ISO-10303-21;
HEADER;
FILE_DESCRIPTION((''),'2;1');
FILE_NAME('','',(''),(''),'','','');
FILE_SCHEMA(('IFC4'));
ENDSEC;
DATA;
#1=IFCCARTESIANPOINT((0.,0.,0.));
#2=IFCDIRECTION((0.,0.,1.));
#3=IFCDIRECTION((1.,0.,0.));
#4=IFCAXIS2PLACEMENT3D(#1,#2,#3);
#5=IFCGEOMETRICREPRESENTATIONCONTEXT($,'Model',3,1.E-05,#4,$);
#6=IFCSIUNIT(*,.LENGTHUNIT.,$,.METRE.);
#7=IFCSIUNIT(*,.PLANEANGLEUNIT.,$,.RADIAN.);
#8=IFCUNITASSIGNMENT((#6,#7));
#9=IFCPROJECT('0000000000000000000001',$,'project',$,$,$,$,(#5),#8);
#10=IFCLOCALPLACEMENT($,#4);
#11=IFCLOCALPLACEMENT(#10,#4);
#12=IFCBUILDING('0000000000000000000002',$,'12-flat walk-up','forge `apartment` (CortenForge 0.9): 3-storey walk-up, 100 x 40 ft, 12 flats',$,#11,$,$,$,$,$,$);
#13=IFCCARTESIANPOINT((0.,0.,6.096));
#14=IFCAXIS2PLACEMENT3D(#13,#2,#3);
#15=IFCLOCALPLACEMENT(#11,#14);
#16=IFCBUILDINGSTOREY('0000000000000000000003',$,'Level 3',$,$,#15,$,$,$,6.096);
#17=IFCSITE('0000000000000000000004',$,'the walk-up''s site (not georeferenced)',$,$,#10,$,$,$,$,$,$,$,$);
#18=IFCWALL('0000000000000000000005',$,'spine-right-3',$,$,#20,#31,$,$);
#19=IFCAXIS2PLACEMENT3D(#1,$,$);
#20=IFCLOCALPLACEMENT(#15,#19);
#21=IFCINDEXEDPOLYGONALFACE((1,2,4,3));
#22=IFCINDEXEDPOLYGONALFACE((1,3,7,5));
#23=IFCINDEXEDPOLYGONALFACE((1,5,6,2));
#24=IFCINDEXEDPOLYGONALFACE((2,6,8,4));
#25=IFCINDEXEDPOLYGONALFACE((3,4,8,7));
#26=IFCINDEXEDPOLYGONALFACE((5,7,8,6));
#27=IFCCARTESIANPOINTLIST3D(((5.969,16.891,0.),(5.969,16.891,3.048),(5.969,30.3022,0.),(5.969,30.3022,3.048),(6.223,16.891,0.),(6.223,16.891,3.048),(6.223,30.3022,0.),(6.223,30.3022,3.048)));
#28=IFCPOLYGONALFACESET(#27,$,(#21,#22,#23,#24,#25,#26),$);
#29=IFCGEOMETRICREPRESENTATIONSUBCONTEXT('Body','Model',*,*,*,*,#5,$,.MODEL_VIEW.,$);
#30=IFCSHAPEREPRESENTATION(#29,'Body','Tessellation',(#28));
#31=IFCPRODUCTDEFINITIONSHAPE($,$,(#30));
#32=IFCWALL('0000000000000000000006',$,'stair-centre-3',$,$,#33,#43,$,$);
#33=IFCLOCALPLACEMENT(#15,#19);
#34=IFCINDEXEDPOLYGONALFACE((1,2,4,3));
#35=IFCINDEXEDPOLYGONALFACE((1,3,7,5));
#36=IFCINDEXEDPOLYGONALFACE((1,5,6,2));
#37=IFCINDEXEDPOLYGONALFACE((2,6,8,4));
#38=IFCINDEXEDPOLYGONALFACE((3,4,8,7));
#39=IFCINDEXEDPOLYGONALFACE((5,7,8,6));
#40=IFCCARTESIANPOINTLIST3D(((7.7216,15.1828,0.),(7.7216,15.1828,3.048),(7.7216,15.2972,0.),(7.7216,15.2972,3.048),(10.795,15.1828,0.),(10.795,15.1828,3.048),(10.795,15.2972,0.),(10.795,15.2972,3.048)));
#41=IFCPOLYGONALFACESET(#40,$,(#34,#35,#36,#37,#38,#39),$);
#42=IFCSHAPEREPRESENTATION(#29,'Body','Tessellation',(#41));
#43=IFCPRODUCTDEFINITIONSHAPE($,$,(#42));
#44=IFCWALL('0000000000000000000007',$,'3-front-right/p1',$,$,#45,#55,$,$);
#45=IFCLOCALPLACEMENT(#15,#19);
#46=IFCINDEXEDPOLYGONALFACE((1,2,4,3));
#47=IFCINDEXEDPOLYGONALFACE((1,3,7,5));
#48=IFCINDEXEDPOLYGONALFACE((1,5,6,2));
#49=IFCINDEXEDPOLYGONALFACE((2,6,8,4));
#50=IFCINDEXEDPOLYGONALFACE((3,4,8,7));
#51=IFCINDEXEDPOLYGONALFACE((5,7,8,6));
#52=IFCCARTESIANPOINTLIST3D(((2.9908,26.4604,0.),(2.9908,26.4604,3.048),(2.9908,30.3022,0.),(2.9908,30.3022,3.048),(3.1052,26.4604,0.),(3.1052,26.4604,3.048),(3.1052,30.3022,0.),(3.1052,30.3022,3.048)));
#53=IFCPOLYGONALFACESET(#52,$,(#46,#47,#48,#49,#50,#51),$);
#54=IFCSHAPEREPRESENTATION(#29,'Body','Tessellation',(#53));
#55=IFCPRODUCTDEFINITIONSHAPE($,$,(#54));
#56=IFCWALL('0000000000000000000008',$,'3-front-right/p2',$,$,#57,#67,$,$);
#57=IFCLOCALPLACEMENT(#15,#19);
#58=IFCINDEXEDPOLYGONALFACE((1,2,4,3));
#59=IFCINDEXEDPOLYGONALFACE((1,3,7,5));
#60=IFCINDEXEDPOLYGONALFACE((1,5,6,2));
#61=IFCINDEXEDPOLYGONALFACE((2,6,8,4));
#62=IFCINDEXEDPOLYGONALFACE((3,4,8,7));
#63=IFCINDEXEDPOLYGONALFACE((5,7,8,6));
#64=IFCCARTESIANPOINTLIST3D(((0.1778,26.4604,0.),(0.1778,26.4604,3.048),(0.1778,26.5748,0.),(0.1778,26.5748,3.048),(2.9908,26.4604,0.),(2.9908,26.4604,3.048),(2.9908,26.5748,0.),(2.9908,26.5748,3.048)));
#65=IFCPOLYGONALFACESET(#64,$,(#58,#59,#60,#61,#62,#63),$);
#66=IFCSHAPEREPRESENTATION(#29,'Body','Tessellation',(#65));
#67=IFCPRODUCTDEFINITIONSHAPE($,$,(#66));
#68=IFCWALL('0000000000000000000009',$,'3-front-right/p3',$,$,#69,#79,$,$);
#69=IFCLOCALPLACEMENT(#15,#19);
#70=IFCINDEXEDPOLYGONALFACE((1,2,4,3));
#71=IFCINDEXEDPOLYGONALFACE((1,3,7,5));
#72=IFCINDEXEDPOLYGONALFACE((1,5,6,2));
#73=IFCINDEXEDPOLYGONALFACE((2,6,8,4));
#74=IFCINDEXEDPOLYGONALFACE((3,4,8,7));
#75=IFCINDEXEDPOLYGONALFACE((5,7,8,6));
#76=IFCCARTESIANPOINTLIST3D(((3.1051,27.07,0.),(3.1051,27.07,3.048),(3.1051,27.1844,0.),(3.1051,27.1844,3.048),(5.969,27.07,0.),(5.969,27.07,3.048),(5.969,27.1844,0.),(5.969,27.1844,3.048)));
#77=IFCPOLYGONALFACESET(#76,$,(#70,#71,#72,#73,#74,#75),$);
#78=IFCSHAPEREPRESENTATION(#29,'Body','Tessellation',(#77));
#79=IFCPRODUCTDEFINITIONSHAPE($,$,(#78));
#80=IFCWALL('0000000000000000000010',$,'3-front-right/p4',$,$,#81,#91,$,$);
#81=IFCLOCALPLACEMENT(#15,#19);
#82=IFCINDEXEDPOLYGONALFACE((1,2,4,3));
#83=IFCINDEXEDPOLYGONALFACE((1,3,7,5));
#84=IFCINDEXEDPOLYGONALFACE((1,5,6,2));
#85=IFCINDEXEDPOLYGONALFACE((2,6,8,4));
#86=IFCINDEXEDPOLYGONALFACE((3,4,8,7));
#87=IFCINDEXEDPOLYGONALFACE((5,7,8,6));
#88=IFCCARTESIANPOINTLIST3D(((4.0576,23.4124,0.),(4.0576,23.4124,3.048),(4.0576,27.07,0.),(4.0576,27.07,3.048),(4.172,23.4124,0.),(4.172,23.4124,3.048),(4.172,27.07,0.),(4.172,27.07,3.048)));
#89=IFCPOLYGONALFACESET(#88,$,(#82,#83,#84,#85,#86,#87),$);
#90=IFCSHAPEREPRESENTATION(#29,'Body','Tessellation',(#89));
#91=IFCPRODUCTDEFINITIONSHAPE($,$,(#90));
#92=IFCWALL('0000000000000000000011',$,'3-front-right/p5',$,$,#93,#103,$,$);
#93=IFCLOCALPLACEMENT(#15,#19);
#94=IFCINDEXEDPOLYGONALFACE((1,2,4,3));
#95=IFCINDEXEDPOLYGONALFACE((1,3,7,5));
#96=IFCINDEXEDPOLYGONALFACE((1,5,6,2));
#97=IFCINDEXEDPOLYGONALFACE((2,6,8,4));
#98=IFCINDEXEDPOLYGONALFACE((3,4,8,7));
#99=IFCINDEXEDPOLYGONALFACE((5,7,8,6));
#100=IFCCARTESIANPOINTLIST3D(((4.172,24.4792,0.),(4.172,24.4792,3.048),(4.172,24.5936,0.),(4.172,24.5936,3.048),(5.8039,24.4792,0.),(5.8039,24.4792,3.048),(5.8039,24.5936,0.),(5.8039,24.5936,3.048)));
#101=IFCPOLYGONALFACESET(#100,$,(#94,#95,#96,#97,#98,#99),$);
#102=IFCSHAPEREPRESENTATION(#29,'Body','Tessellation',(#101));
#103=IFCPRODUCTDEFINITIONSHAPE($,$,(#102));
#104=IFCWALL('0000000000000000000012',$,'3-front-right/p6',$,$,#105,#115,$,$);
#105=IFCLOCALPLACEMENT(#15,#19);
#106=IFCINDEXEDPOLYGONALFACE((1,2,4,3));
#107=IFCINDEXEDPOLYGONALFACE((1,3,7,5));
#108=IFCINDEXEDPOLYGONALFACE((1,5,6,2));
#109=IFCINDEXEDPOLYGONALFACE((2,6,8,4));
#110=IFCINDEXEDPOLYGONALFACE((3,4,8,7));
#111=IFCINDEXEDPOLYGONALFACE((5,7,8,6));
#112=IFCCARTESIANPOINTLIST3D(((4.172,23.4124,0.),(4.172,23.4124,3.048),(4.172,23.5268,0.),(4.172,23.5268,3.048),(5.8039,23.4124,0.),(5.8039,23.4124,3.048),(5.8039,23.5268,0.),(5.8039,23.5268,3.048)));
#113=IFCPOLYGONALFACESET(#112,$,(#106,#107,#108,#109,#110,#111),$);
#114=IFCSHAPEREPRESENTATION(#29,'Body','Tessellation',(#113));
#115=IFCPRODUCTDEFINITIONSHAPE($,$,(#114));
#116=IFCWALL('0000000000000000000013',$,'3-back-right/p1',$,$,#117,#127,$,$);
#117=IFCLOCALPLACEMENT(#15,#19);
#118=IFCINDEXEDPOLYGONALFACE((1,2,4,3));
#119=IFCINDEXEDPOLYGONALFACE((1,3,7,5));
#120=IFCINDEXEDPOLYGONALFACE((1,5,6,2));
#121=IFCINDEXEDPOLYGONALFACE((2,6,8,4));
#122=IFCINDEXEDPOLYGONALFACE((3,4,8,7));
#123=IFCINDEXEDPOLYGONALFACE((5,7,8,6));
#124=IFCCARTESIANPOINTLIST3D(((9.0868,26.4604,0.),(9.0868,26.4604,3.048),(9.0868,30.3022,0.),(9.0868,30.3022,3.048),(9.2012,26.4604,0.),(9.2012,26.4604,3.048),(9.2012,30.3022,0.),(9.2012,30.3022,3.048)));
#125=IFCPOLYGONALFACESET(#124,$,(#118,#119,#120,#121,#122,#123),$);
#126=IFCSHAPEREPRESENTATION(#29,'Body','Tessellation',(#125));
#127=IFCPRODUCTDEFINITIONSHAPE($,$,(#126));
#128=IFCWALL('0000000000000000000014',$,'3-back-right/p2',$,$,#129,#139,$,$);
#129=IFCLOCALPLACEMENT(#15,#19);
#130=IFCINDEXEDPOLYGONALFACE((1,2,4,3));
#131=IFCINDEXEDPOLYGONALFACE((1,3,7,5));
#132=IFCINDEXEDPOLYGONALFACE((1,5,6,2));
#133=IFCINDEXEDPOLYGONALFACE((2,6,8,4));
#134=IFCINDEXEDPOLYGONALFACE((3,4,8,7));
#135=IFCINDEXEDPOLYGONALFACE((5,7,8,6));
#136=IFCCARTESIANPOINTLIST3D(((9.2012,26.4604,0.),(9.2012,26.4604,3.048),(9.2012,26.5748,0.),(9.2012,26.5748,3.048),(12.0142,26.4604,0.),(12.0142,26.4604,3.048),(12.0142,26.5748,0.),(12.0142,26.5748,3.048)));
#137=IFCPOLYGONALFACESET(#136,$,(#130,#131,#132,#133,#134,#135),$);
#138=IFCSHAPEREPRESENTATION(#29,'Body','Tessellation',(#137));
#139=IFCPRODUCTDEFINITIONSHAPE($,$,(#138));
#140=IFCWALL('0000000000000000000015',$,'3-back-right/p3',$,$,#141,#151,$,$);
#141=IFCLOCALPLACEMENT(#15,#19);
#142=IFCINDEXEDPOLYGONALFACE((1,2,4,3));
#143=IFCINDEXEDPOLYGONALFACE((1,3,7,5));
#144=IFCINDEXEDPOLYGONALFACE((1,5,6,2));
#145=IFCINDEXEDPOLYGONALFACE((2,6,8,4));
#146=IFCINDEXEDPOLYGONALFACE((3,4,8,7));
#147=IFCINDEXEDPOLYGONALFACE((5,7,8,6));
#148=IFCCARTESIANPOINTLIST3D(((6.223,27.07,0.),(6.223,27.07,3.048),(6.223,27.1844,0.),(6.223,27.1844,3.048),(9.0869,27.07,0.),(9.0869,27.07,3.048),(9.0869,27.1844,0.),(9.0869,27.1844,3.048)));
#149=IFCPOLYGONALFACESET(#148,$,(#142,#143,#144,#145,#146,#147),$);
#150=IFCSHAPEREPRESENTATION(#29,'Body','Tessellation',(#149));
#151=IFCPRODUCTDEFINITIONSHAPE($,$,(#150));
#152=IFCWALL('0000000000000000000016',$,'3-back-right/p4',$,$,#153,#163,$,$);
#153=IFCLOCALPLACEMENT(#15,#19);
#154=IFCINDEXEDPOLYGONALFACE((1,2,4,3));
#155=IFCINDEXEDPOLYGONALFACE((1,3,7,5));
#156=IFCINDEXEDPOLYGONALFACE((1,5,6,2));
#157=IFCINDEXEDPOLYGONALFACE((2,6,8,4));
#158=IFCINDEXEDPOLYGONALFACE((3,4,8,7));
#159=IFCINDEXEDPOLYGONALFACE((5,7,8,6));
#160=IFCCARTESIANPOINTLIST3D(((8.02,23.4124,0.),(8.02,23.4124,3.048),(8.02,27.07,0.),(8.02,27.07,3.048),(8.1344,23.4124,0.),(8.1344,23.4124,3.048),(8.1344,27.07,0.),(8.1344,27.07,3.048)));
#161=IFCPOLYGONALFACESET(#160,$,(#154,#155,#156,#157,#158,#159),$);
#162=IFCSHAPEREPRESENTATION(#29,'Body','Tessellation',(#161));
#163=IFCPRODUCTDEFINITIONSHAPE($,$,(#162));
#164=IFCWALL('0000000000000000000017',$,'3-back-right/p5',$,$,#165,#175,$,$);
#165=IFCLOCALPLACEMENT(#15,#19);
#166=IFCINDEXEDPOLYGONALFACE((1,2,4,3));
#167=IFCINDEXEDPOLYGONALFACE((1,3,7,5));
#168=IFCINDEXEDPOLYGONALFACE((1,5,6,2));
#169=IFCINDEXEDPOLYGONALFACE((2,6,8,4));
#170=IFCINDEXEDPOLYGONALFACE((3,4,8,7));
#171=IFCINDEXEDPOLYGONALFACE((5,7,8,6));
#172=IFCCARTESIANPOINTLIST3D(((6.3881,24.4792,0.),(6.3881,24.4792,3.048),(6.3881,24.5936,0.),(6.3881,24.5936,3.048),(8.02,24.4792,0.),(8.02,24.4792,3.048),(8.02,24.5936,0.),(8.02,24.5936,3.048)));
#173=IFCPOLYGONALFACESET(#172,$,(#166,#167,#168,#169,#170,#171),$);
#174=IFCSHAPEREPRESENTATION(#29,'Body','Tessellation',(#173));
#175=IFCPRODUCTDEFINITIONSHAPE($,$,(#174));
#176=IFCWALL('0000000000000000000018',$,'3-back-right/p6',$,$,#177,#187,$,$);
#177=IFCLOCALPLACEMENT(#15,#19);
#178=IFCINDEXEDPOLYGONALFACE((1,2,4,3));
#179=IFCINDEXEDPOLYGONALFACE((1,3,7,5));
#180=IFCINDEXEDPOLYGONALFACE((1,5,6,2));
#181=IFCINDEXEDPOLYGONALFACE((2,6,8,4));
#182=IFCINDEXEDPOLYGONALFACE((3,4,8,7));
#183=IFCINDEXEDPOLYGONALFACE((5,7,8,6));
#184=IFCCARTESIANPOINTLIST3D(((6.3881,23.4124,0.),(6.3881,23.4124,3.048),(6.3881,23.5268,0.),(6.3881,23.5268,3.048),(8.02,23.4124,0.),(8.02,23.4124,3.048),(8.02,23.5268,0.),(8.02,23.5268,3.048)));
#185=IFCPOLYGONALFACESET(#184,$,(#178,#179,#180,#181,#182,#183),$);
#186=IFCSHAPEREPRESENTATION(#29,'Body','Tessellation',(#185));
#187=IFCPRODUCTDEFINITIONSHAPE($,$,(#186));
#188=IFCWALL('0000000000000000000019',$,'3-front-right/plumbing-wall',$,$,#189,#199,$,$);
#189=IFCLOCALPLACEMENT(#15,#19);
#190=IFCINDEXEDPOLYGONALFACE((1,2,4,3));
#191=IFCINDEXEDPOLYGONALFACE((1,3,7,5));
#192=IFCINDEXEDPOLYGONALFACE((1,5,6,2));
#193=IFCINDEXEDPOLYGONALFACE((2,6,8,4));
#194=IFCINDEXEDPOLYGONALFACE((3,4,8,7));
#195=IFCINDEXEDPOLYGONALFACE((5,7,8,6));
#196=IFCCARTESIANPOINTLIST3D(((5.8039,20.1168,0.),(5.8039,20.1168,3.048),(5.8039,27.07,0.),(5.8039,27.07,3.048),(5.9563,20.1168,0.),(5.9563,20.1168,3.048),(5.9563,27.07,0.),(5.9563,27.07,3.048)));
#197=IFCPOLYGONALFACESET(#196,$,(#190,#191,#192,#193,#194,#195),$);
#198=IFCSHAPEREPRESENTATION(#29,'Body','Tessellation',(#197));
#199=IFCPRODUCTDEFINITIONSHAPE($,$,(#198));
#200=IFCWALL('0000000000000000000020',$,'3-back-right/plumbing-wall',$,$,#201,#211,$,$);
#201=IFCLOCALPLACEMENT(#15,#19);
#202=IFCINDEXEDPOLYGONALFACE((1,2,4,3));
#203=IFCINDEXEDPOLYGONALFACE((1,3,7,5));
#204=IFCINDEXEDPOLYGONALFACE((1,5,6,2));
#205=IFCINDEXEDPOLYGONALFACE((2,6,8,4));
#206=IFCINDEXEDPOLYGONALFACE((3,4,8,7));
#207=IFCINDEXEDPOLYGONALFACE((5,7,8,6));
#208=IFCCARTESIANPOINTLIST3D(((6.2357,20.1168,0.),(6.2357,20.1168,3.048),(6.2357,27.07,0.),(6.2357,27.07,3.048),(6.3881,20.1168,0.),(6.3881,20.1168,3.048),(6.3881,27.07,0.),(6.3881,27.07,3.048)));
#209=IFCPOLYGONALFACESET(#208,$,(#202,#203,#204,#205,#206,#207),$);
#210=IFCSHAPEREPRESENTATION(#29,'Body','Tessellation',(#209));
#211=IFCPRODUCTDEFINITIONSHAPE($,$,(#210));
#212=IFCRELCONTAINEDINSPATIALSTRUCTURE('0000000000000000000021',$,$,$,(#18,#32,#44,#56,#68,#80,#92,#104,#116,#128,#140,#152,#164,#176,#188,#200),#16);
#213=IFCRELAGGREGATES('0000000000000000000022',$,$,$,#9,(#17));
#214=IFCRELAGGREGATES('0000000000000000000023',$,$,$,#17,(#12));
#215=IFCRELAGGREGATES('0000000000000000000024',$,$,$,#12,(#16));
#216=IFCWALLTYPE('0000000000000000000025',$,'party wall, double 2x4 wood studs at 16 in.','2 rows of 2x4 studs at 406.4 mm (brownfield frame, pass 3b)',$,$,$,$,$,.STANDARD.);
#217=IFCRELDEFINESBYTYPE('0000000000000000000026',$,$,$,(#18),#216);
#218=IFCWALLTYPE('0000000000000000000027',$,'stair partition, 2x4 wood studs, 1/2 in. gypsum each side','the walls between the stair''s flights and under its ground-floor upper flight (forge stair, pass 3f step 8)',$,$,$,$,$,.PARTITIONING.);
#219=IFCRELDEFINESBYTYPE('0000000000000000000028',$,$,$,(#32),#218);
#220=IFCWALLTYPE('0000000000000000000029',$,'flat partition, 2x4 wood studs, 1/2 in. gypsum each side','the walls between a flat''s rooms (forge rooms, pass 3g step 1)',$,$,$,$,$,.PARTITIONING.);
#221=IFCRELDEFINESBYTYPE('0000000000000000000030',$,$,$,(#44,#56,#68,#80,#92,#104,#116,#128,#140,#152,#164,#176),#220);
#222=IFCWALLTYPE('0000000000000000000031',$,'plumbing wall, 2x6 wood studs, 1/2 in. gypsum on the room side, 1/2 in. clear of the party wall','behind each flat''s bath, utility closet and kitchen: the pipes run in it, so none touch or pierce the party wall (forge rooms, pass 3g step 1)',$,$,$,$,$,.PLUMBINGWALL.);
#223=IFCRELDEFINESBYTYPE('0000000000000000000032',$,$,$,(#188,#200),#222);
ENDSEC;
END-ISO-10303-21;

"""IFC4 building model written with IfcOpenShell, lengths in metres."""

from ifc_helpers import new_model, si_unit, frame, frame_2d, origin, origin_with_axes, place, context, subcontext, project, spatial, rectangle, extrude, type_object, element, save


model = new_model("IFC4")

# Units and contexts
model_context = context("Model", 3, precision=1e-05, world=origin_with_axes())
body_context = subcontext(model_context, "Body", "Model", "MODEL_VIEW")
ifc_project = project(units=[si_unit("LENGTHUNIT", "METRE"), si_unit("PLANEANGLEUNIT", "RADIAN")], contexts=[model_context])

# Site, building, storey
site_placement = place(None, origin_with_axes())
site = spatial("IfcSite", under=ifc_project, at=site_placement, Name="the walk-up's site (not georeferenced)")
building_placement = place(site_placement, origin_with_axes())
building = spatial("IfcBuilding", under=site, at=building_placement, Name="12-flat walk-up", Description="forge `apartment` (CortenForge 0.9): 3-storey walk-up, 100 x 40 ft, 12 flats")
storey_placement = place(building_placement, frame((0.0, 0.0, 6.096), z_axis=(0.0, 0.0, 1.0), x_axis=(1.0, 0.0, 0.0)))
storey = spatial("IfcBuildingStorey", under=building, at=storey_placement, Name="Level 3", Elevation=6.096)

# Walls
wall_type_1 = type_object("IfcWallType", Name="party wall, double 2x4 wood studs at 16 in.", Description="2 rows of 2x4 studs at 406.4 mm (brownfield frame, pass 3b)", PredefinedType="STANDARD")
wall_1_placement = place(storey_placement, frame((5.969, 16.891, 0.0), z_axis=(0.0, 0.0, 1.0), x_axis=(1.0, 0.0, 0.0)))
element("IfcWall", 1, at=wall_1_placement, inside=storey, type_object=wall_type_1, Name="spine-right-3", context=body_context, shape_type="SweptSolid", body=[
    extrude(rectangle(XDim=0.254, YDim=13.4112, at=frame_2d((0.127, 6.7056))), origin(), (0.0, 0.0, 1.0), 3.048),
])
wall_type_2 = type_object("IfcWallType", Name="stair partition, 2x4 wood studs, 1/2 in. gypsum each side", Description="the walls between the stair's flights and under its ground-floor upper flight (forge stair, pass 3f step 8)", PredefinedType="PARTITIONING")
wall_2_placement = place(storey_placement, frame((7.7216, 15.1829, 0.0), z_axis=(0.0, 0.0, 1.0), x_axis=(1.0, 0.0, 0.0)))
element("IfcWall", 2, at=wall_2_placement, inside=storey, type_object=wall_type_2, Name="stair-centre-3", context=body_context, shape_type="SweptSolid", body=[
    extrude(rectangle(XDim=3.0734, YDim=0.1143, at=frame_2d((1.5367, 0.0572))), origin(), (0.0, 0.0, 1.0), 3.048),
])
wall_type_3 = type_object("IfcWallType", Name="flat partition, 2x4 wood studs, 1/2 in. gypsum each side", Description="the walls between a flat's rooms (forge rooms, pass 3g step 1)", PredefinedType="PARTITIONING")
wall_3_placement = place(storey_placement, frame((2.9909, 26.4605, 0.0), z_axis=(0.0, 0.0, 1.0), x_axis=(1.0, 0.0, 0.0)))
element("IfcWall", 3, at=wall_3_placement, inside=storey, type_object=wall_type_3, Name="3-front-right/p1", context=body_context, shape_type="SweptSolid", body=[
    extrude(rectangle(XDim=0.1143, YDim=3.8417, at=frame_2d((0.0572, 1.9209))), origin(), (0.0, 0.0, 1.0), 3.048),
])
wall_4_placement = place(storey_placement, frame((0.1778, 26.4605, 0.0), z_axis=(0.0, 0.0, 1.0), x_axis=(1.0, 0.0, 0.0)))
element("IfcWall", 4, at=wall_4_placement, inside=storey, type_object=wall_type_3, Name="3-front-right/p2", context=body_context, shape_type="SweptSolid", body=[
    extrude(rectangle(XDim=2.8131, YDim=0.1143, at=frame_2d((1.4065, 0.0572))), origin(), (0.0, 0.0, 1.0), 3.048),
])
wall_5_placement = place(storey_placement, frame((3.1051, 27.07, 0.0), z_axis=(0.0, 0.0, 1.0), x_axis=(1.0, 0.0, 0.0)))
element("IfcWall", 5, at=wall_5_placement, inside=storey, type_object=wall_type_3, Name="3-front-right/p3", context=body_context, shape_type="SweptSolid", body=[
    extrude(rectangle(XDim=2.8639, YDim=0.1143, at=frame_2d((1.4319, 0.0572))), origin(), (0.0, 0.0, 1.0), 3.048),
])
wall_6_placement = place(storey_placement, frame((4.0576, 23.4124, 0.0), z_axis=(0.0, 0.0, 1.0), x_axis=(1.0, 0.0, 0.0)))
element("IfcWall", 6, at=wall_6_placement, inside=storey, type_object=wall_type_3, Name="3-front-right/p4", context=body_context, shape_type="SweptSolid", body=[
    extrude(rectangle(XDim=0.1143, YDim=3.6576, at=frame_2d((0.0572, 1.8288))), origin(), (0.0, 0.0, 1.0), 3.048),
])
for number, where, z_axis, x_axis, name in (
    (7, (4.1719, 24.4793, 0.0), (0.0, 0.0, 1.0), (1.0, 0.0, 0.0), "3-front-right/p5"),
    (8, (4.1719, 23.4124, 0.0), (0.0, 0.0, 1.0), (1.0, 0.0, 0.0), "3-front-right/p6"),
):
    element("IfcWall", number, at=place(storey_placement, frame(where, z_axis=z_axis, x_axis=x_axis)), inside=storey, type_object=wall_type_3, Name=name, context=body_context, shape_type="SweptSolid", body=[
        extrude(rectangle(XDim=1.6319, YDim=0.1143, at=frame_2d((0.816, 0.0572))), origin(), (0.0, 0.0, 1.0), 3.048),
    ])
wall_7_placement = place(storey_placement, frame((9.0869, 26.4605, 0.0), z_axis=(0.0, 0.0, 1.0), x_axis=(1.0, 0.0, 0.0)))
element("IfcWall", 9, at=wall_7_placement, inside=storey, type_object=wall_type_3, Name="3-back-right/p1", context=body_context, shape_type="SweptSolid", body=[
    extrude(rectangle(XDim=0.1143, YDim=3.8417, at=frame_2d((0.0572, 1.9209))), origin(), (0.0, 0.0, 1.0), 3.048),
])
wall_8_placement = place(storey_placement, frame((9.2012, 26.4605, 0.0), z_axis=(0.0, 0.0, 1.0), x_axis=(1.0, 0.0, 0.0)))
element("IfcWall", 10, at=wall_8_placement, inside=storey, type_object=wall_type_3, Name="3-back-right/p2", context=body_context, shape_type="SweptSolid", body=[
    extrude(rectangle(XDim=2.8131, YDim=0.1143, at=frame_2d((1.4065, 0.0572))), origin(), (0.0, 0.0, 1.0), 3.048),
])
wall_9_placement = place(storey_placement, frame((6.223, 27.07, 0.0), z_axis=(0.0, 0.0, 1.0), x_axis=(1.0, 0.0, 0.0)))
element("IfcWall", 11, at=wall_9_placement, inside=storey, type_object=wall_type_3, Name="3-back-right/p3", context=body_context, shape_type="SweptSolid", body=[
    extrude(rectangle(XDim=2.8639, YDim=0.1143, at=frame_2d((1.4319, 0.0572))), origin(), (0.0, 0.0, 1.0), 3.048),
])
wall_10_placement = place(storey_placement, frame((8.02, 23.4124, 0.0), z_axis=(0.0, 0.0, 1.0), x_axis=(1.0, 0.0, 0.0)))
element("IfcWall", 12, at=wall_10_placement, inside=storey, type_object=wall_type_3, Name="3-back-right/p4", context=body_context, shape_type="SweptSolid", body=[
    extrude(rectangle(XDim=0.1143, YDim=3.6576, at=frame_2d((0.0572, 1.8288))), origin(), (0.0, 0.0, 1.0), 3.048),
])
for number, where, z_axis, x_axis, name in (
    (13, (6.3881, 24.4793, 0.0), (0.0, 0.0, 1.0), (1.0, 0.0, 0.0), "3-back-right/p5"),
    (14, (6.3881, 23.4124, 0.0), (0.0, 0.0, 1.0), (1.0, 0.0, 0.0), "3-back-right/p6"),
):
    element("IfcWall", number, at=place(storey_placement, frame(where, z_axis=z_axis, x_axis=x_axis)), inside=storey, type_object=wall_type_3, Name=name, context=body_context, shape_type="SweptSolid", body=[
        extrude(rectangle(XDim=1.6319, YDim=0.1143, at=frame_2d((0.816, 0.0572))), origin(), (0.0, 0.0, 1.0), 3.048),
    ])
wall_type_4 = type_object("IfcWallType", Name="plumbing wall, 2x6 wood studs, 1/2 in. gypsum on the room side, 1/2 in. clear of the party wall", Description="behind each flat's bath, utility closet and kitchen: the pipes run in it, so none touch or pierce the party wall (forge rooms, pass 3g step 1)", PredefinedType="PLUMBINGWALL")
for number, where, z_axis, x_axis, name in (
    (15, (5.8039, 20.1168, 0.0), (0.0, 0.0, 1.0), (1.0, 0.0, 0.0), "3-front-right/plumbing-wall"),
    (16, (6.2357, 20.1168, 0.0), (0.0, 0.0, 1.0), (1.0, 0.0, 0.0), "3-back-right/plumbing-wall"),
):
    element("IfcWall", number, at=place(storey_placement, frame(where, z_axis=z_axis, x_axis=x_axis)), inside=storey, type_object=wall_type_4, Name=name, context=body_context, shape_type="SweptSolid", body=[
        extrude(rectangle(XDim=0.1524, YDim=6.9532, at=frame_2d((0.0762, 3.4766))), origin(), (0.0, 0.0, 1.0), 3.048),
    ])

save(model, "model.ifc")
